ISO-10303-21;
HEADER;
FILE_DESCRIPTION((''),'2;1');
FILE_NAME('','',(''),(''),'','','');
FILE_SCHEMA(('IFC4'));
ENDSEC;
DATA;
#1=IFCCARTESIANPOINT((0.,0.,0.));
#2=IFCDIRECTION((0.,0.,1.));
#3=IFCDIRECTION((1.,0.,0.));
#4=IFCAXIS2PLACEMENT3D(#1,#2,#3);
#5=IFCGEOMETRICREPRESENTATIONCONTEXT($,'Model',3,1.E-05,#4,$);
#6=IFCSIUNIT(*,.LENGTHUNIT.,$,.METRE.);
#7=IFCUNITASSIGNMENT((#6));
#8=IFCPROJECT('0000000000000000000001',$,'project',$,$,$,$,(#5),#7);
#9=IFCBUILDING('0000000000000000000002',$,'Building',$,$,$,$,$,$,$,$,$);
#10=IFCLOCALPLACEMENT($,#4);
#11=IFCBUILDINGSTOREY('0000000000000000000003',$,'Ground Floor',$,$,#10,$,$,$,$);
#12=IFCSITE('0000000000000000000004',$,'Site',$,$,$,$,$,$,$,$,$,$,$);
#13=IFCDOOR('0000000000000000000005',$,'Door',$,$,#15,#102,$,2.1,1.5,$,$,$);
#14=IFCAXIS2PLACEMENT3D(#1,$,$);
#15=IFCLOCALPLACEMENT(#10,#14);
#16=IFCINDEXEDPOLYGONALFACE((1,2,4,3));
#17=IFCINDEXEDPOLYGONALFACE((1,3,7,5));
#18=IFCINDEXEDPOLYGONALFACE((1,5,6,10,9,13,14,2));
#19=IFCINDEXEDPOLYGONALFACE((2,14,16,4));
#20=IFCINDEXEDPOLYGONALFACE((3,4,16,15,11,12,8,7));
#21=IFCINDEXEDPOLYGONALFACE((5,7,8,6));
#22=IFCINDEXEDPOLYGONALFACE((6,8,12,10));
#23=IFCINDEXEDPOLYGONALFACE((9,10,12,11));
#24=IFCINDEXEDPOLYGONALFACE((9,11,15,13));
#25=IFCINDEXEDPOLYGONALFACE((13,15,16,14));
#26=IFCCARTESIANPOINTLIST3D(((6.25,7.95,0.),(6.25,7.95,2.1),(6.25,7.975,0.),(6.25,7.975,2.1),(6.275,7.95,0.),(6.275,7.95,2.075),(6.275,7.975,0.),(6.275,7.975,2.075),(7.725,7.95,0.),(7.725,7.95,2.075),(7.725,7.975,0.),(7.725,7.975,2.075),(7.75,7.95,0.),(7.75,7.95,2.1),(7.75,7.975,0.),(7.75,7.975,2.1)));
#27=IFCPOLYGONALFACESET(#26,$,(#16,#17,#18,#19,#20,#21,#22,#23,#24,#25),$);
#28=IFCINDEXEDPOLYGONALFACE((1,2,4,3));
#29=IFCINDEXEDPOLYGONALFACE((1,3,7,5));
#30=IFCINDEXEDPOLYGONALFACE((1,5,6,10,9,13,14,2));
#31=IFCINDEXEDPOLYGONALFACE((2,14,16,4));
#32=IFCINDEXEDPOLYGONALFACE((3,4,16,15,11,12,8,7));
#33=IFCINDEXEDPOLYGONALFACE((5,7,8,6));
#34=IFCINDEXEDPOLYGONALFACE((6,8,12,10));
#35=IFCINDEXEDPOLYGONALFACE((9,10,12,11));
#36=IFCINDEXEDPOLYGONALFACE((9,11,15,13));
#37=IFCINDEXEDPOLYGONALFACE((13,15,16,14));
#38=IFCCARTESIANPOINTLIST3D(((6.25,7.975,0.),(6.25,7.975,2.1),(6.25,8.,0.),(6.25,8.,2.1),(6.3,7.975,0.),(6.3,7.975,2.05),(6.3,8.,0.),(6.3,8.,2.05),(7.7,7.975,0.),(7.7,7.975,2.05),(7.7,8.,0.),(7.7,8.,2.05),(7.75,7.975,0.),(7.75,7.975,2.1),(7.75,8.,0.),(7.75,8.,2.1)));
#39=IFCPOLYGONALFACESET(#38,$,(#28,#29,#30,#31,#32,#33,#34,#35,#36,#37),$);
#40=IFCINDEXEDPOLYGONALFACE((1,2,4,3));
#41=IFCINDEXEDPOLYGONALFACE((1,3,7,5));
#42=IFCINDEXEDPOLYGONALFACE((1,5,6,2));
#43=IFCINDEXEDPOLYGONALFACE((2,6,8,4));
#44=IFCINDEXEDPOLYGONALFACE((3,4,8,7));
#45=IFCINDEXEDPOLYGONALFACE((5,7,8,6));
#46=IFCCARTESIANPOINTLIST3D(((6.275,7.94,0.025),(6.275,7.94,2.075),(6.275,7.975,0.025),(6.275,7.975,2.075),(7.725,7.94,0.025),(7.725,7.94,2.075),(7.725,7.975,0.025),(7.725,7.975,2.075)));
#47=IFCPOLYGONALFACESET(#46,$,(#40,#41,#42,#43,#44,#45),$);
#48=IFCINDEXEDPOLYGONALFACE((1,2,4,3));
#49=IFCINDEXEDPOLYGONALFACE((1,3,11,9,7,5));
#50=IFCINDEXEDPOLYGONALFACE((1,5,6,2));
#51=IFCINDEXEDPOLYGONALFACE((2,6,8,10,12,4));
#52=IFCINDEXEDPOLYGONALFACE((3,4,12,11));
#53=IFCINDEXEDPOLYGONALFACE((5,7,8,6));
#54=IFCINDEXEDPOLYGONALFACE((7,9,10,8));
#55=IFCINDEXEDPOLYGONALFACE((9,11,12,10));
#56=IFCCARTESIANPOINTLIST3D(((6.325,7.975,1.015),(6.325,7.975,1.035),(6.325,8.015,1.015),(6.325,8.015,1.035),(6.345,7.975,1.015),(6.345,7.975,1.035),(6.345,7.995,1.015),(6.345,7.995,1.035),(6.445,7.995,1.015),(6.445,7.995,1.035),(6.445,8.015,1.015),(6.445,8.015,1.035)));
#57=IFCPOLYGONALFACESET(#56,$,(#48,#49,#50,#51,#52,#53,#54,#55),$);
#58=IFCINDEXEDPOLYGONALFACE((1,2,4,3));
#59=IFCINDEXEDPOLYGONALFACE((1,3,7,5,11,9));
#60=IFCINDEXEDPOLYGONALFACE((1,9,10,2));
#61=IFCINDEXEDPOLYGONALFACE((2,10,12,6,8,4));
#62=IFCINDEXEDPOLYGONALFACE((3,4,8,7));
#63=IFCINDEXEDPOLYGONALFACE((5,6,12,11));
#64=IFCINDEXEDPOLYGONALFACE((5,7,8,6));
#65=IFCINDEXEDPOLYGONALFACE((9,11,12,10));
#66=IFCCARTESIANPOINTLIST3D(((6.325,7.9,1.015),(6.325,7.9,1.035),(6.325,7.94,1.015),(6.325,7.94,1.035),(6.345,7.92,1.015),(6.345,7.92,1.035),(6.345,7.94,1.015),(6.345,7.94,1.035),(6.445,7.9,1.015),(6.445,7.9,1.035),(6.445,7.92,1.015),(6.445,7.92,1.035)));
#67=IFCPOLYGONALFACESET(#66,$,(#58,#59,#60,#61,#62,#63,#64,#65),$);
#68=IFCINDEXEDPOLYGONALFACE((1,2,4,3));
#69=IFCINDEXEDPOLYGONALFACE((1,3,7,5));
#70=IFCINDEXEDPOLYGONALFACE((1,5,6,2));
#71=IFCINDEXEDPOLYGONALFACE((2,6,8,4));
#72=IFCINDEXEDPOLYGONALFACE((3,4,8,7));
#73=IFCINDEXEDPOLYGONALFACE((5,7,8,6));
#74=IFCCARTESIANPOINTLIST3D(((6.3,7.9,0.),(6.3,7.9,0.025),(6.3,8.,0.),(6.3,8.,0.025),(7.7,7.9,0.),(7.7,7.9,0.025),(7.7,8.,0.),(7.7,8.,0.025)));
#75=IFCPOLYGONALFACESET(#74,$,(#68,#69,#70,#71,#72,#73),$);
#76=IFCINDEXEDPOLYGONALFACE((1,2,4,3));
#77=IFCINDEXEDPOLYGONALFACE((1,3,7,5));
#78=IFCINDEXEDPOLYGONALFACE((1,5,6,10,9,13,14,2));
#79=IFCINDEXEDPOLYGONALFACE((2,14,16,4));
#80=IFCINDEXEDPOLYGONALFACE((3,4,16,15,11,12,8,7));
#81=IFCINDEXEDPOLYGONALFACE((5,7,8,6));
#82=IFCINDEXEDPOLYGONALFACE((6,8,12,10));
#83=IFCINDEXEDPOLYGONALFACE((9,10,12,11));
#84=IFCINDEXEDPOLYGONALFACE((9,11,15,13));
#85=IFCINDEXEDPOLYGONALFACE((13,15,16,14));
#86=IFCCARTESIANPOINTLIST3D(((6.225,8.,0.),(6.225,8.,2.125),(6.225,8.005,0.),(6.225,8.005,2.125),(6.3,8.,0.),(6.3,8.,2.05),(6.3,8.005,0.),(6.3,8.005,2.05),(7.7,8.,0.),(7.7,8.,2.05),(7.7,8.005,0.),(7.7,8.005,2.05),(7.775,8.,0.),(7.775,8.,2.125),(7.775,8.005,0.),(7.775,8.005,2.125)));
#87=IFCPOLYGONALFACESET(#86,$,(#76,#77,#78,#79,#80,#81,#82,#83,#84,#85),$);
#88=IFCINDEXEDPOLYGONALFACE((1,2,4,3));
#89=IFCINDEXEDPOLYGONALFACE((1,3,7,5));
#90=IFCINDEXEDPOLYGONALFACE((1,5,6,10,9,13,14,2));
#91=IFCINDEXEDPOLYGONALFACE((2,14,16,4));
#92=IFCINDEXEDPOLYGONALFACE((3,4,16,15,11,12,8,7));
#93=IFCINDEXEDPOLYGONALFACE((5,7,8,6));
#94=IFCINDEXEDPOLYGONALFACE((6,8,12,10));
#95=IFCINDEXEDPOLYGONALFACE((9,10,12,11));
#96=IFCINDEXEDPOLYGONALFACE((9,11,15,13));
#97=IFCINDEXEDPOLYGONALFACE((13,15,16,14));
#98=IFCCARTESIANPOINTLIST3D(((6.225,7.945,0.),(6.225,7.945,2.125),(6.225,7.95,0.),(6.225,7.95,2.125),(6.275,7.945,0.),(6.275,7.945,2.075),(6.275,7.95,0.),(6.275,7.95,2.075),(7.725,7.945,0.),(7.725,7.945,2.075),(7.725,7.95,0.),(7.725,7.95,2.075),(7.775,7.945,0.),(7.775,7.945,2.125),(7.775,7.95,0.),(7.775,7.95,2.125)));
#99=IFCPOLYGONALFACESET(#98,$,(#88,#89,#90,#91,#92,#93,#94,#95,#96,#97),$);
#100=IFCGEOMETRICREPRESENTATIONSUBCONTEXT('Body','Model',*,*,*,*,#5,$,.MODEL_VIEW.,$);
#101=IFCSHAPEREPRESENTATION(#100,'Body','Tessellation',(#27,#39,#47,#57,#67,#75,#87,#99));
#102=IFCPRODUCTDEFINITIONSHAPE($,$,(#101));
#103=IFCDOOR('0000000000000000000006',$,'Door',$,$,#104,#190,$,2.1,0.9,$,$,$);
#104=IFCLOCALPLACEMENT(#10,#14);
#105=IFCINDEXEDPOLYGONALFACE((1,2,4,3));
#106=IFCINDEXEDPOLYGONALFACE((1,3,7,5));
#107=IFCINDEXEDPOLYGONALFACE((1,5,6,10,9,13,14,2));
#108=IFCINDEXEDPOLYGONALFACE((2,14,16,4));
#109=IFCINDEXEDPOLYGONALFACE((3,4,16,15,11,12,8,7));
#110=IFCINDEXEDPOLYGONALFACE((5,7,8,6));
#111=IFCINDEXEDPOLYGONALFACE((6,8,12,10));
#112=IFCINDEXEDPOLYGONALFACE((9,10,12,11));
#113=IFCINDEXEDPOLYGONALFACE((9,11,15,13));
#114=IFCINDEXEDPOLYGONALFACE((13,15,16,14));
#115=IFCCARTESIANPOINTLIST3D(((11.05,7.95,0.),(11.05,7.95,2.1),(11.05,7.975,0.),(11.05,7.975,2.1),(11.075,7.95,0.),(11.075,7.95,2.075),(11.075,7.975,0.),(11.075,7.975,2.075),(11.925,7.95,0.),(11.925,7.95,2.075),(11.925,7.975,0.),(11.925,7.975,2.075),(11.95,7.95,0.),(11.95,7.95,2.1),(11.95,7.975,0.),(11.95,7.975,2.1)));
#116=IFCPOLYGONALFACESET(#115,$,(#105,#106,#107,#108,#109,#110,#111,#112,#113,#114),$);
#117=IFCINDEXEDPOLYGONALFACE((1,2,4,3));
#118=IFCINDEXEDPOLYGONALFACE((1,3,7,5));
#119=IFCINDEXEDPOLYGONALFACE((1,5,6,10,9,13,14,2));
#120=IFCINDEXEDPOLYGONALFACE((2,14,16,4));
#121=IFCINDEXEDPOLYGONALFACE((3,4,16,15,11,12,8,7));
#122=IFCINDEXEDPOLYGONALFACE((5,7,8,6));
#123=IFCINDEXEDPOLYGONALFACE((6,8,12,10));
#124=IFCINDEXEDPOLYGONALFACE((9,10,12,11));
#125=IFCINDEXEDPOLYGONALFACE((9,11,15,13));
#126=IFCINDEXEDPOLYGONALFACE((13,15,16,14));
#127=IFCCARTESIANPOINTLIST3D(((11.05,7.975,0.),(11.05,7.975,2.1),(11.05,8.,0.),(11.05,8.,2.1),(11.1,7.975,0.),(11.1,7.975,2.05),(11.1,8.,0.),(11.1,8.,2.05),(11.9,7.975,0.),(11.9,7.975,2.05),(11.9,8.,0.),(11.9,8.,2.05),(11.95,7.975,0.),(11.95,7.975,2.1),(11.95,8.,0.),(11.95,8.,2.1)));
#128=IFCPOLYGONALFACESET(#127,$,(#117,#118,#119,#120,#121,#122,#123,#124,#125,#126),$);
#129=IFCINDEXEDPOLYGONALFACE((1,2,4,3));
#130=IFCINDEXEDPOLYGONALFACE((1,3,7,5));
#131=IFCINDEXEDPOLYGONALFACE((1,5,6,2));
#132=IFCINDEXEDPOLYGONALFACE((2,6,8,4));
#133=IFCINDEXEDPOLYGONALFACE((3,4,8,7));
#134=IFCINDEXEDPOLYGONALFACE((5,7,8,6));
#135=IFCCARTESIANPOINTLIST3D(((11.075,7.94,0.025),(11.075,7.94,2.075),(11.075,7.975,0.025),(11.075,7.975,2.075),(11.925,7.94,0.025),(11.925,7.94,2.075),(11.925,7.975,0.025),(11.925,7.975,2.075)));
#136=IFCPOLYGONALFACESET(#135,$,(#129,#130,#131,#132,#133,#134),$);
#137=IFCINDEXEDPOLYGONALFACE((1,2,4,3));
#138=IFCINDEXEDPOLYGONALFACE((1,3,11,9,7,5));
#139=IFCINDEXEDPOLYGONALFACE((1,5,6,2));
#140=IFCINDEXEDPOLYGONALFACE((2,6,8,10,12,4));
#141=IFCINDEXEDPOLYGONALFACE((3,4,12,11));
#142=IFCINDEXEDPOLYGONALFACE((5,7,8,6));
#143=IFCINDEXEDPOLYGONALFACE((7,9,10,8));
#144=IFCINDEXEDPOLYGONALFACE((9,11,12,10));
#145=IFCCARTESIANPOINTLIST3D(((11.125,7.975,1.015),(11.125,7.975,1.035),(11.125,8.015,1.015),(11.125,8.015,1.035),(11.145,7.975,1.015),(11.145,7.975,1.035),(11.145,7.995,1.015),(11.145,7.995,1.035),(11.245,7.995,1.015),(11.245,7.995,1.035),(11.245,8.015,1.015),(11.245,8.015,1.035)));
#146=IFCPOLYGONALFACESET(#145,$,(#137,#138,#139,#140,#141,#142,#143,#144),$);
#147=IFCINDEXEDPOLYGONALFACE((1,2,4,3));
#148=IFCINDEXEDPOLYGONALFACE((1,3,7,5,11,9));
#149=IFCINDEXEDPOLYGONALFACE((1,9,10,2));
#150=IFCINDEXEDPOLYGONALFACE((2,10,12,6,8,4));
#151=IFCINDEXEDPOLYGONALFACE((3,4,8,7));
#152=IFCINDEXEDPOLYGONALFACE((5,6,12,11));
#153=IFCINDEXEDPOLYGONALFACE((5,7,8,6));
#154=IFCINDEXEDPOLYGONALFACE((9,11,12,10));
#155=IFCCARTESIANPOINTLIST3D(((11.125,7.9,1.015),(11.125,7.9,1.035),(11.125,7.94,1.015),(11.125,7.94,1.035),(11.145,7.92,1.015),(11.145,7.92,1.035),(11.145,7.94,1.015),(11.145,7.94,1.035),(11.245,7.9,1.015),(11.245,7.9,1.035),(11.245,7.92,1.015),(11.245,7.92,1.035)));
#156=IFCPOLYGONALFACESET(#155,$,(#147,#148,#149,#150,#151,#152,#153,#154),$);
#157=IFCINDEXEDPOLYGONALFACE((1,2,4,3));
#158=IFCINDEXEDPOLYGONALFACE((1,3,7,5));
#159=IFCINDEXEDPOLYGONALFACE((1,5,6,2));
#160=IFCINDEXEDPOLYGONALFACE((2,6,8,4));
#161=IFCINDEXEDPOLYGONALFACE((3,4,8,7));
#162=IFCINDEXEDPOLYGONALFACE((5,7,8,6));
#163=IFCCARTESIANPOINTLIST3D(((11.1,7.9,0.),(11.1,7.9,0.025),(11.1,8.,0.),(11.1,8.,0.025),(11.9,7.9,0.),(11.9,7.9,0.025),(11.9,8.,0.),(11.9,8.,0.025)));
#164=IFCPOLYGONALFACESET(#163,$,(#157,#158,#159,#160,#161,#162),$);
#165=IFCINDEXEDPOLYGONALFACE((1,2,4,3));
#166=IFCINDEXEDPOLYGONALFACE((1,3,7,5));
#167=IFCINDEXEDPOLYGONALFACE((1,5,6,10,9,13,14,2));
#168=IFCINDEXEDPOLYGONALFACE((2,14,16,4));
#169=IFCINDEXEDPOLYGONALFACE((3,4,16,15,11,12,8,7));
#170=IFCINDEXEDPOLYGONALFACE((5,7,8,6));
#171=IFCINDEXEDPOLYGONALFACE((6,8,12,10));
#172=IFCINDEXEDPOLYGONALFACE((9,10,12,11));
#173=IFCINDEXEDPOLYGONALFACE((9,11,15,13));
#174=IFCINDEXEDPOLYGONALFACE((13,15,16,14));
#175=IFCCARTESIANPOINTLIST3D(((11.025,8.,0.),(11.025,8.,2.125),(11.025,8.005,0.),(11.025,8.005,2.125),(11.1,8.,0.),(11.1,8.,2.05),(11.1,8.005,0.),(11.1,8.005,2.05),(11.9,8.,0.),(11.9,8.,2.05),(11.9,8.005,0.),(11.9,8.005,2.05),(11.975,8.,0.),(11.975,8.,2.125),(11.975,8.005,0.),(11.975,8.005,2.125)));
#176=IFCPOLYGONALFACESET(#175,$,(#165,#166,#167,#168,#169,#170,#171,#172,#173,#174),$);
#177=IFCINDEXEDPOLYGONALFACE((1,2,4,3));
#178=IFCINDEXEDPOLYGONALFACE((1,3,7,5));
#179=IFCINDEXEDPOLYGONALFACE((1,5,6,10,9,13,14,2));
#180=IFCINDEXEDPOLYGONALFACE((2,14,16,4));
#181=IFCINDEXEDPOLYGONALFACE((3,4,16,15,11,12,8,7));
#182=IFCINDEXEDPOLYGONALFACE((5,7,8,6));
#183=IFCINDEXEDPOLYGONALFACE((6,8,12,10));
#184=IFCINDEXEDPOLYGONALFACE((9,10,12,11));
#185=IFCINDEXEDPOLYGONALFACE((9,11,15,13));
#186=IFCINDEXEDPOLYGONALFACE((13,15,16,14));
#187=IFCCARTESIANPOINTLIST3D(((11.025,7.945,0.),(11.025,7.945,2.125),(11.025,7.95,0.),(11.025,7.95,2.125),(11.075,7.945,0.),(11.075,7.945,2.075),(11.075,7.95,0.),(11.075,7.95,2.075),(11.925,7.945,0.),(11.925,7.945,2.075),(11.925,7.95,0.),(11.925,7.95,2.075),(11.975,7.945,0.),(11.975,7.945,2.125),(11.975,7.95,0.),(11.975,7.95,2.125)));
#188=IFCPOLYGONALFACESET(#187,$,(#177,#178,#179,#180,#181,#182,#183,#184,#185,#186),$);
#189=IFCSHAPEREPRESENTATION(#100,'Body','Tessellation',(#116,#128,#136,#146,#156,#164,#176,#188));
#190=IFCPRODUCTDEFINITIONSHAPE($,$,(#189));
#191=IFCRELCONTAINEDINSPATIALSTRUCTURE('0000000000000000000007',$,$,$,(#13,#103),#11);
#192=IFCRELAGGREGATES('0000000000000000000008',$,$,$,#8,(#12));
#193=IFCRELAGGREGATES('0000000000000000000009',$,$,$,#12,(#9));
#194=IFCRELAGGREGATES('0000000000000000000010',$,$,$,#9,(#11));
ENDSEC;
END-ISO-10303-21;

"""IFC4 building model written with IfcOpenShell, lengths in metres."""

from ifc_helpers import new_model, si_unit, frame, origin_with_axes, place, context, subcontext, project, spatial, line, indexed_curve, outline, extrude, element, save


model = new_model("IFC4")

# Units and contexts
model_context = context("Model", 3, precision=1e-05, world=origin_with_axes())
body_context = subcontext(model_context, "Body", "Model", "MODEL_VIEW")
ifc_project = project(units=[si_unit("LENGTHUNIT", "METRE")], contexts=[model_context])

# Site, building, storey
site = spatial("IfcSite", under=ifc_project, Name="Site")
building = spatial("IfcBuilding", under=site, Name="Building")
storey_placement = place(None, origin_with_axes())
storey = spatial("IfcBuildingStorey", under=building, at=storey_placement, Name="Ground Floor")

# Doors
door_1_placement = place(storey_placement, frame((7.75, 8.0, 0.0), z_axis=(0.0, 0.0, 1.0), x_axis=(-1.0, 0.0, 0.0)))
element("IfcDoor", 1, at=door_1_placement, inside=storey, Name="Door", OverallHeight=2.1, OverallWidth=1.5, context=body_context, shape_type="SweptSolid", body=[
    extrude(outline(indexed_curve([(0.0, 0.0), (0.0, 2.1), (1.5, 2.1), (1.5, 0.0), (1.475, 0.0), (1.475, 2.075), (0.025, 2.075), (0.025, 0.0)], segments=[line(1, 2, 3, 4, 5, 6, 7, 8, 1)])), frame((0.0, 0.025, 0.0), z_axis=(0.0, -1.0, 0.0), x_axis=(1.0, 0.0, 0.0)), (0.0, 0.0, -1.0), 0.025),
    extrude(outline(indexed_curve([(0.0, 0.0), (0.0, 2.1), (1.5, 2.1), (1.5, 0.0), (1.45, 0.0), (1.45, 2.05), (0.05, 2.05), (0.05, 0.0)], segments=[line(1, 2, 3, 4, 5, 6, 7, 8, 1)])), frame((0.0, 0.0, 0.0), z_axis=(0.0, -1.0, 0.0), x_axis=(1.0, 0.0, 0.0)), (0.0, 0.0, -1.0), 0.025),
    extrude(outline(indexed_curve([(0.0, 0.0), (1.45, 0.0), (1.45, 0.035), (0.0, 0.035)], segments=[line(1, 2, 3, 4, 1)])), frame((0.025, 0.025, 0.025), z_axis=(0.0, 0.0, 1.0), x_axis=(1.0, 0.0, 0.0)), (0.0, 0.0, 1.0), 2.05),
    extrude(outline(indexed_curve([(0.0, 0.0), (0.0, -0.04), (-0.12, -0.04), (-0.12, -0.02), (-0.02, -0.02), (-0.02, 0.0)], segments=[line(1, 2, 3, 4, 5, 6, 1)])), frame((1.425, 0.025, 1.015), z_axis=(0.0, 0.0, 1.0), x_axis=(1.0, 0.0, 0.0)), (0.0, 0.0, 1.0), 0.02),
    extrude(outline(indexed_curve([(0.0, 0.0), (0.0, 0.04), (-0.12, 0.04), (-0.12, 0.02), (-0.02, 0.02), (-0.02, 0.0)], segments=[line(1, 2, 3, 4, 5, 6, 1)])), frame((1.425, 0.06, 1.015), z_axis=(0.0, 0.0, 1.0), x_axis=(1.0, 0.0, 0.0)), (0.0, 0.0, 1.0), 0.02),
    extrude(outline(indexed_curve([(0.0, 0.0), (1.4, 0.0), (1.4, 0.1), (0.0, 0.1)], segments=[line(1, 2, 3, 4, 1)])), frame((0.05, 0.0, 0.0), z_axis=(0.0, 0.0, 1.0), x_axis=(1.0, 0.0, 0.0)), (0.0, 0.0, 1.0), 0.025),
    extrude(outline(indexed_curve([(0.0, 0.0), (0.0, 2.125), (1.55, 2.125), (1.55, 0.0), (1.475, 0.0), (1.475, 2.05), (0.075, 2.05), (0.075, 0.0)], segments=[line(1, 2, 3, 4, 5, 6, 7, 8, 1)])), frame((-0.025, -0.005, 0.0), z_axis=(0.0, -1.0, 0.0), x_axis=(1.0, 0.0, 0.0)), (0.0, 0.0, -1.0), 0.005),
    extrude(outline(indexed_curve([(0.0, 0.0), (0.0, 2.125), (1.55, 2.125), (1.55, 0.0), (1.5, 0.0), (1.5, 2.075), (0.05, 2.075), (0.05, 0.0)], segments=[line(1, 2, 3, 4, 5, 6, 7, 8, 1)])), frame((-0.025, 0.05, 0.0), z_axis=(0.0, -1.0, 0.0), x_axis=(1.0, 0.0, 0.0)), (0.0, 0.0, -1.0), 0.005),
])
door_2_placement = place(storey_placement, frame((11.95, 8.0, 0.0), z_axis=(0.0, 0.0, 1.0), x_axis=(-1.0, 0.0, 0.0)))
element("IfcDoor", 2, at=door_2_placement, inside=storey, Name="Door", OverallHeight=2.1, OverallWidth=0.9, context=body_context, shape_type="SweptSolid", body=[
    extrude(outline(indexed_curve([(0.0, 0.0), (0.0, 2.1), (0.9, 2.1), (0.9, 0.0), (0.875, 0.0), (0.875, 2.075), (0.025, 2.075), (0.025, 0.0)], segments=[line(1, 2, 3, 4, 5, 6, 7, 8, 1)])), frame((0.0, 0.025, 0.0), z_axis=(0.0, -1.0, 0.0), x_axis=(1.0, 0.0, 0.0)), (0.0, 0.0, -1.0), 0.025),
    extrude(outline(indexed_curve([(0.0, 0.0), (0.0, 2.1), (0.9, 2.1), (0.9, 0.0), (0.85, 0.0), (0.85, 2.05), (0.05, 2.05), (0.05, 0.0)], segments=[line(1, 2, 3, 4, 5, 6, 7, 8, 1)])), frame((0.0, 0.0, 0.0), z_axis=(0.0, -1.0, 0.0), x_axis=(1.0, 0.0, 0.0)), (0.0, 0.0, -1.0), 0.025),
    extrude(outline(indexed_curve([(0.0, 0.0), (0.85, 0.0), (0.85, 0.035), (0.0, 0.035)], segments=[line(1, 2, 3, 4, 1)])), frame((0.025, 0.025, 0.025), z_axis=(0.0, 0.0, 1.0), x_axis=(1.0, 0.0, 0.0)), (0.0, 0.0, 1.0), 2.05),
    extrude(outline(indexed_curve([(0.0, 0.0), (0.0, -0.04), (-0.12, -0.04), (-0.12, -0.02), (-0.02, -0.02), (-0.02, 0.0)], segments=[line(1, 2, 3, 4, 5, 6, 1)])), frame((0.825, 0.025, 1.015), z_axis=(0.0, 0.0, 1.0), x_axis=(1.0, 0.0, 0.0)), (0.0, 0.0, 1.0), 0.02),
    extrude(outline(indexed_curve([(0.0, 0.0), (0.0, 0.04), (-0.12, 0.04), (-0.12, 0.02), (-0.02, 0.02), (-0.02, 0.0)], segments=[line(1, 2, 3, 4, 5, 6, 1)])), frame((0.825, 0.06, 1.015), z_axis=(0.0, 0.0, 1.0), x_axis=(1.0, 0.0, 0.0)), (0.0, 0.0, 1.0), 0.02),
    extrude(outline(indexed_curve([(0.0, 0.0), (0.8, 0.0), (0.8, 0.1), (0.0, 0.1)], segments=[line(1, 2, 3, 4, 1)])), frame((0.05, 0.0, 0.0), z_axis=(0.0, 0.0, 1.0), x_axis=(1.0, 0.0, 0.0)), (0.0, 0.0, 1.0), 0.025),
    extrude(outline(indexed_curve([(0.0, 0.0), (0.0, 2.125), (0.95, 2.125), (0.95, 0.0), (0.875, 0.0), (0.875, 2.05), (0.075, 2.05), (0.075, 0.0)], segments=[line(1, 2, 3, 4, 5, 6, 7, 8, 1)])), frame((-0.025, -0.005, 0.0), z_axis=(0.0, -1.0, 0.0), x_axis=(1.0, 0.0, 0.0)), (0.0, 0.0, -1.0), 0.005),
    extrude(outline(indexed_curve([(0.0, 0.0), (0.0, 2.125), (0.95, 2.125), (0.95, 0.0), (0.9, 0.0), (0.9, 2.075), (0.05, 2.075), (0.05, 0.0)], segments=[line(1, 2, 3, 4, 5, 6, 7, 8, 1)])), frame((-0.025, 0.05, 0.0), z_axis=(0.0, -1.0, 0.0), x_axis=(1.0, 0.0, 0.0)), (0.0, 0.0, -1.0), 0.005),
])

save(model, "model.ifc")
